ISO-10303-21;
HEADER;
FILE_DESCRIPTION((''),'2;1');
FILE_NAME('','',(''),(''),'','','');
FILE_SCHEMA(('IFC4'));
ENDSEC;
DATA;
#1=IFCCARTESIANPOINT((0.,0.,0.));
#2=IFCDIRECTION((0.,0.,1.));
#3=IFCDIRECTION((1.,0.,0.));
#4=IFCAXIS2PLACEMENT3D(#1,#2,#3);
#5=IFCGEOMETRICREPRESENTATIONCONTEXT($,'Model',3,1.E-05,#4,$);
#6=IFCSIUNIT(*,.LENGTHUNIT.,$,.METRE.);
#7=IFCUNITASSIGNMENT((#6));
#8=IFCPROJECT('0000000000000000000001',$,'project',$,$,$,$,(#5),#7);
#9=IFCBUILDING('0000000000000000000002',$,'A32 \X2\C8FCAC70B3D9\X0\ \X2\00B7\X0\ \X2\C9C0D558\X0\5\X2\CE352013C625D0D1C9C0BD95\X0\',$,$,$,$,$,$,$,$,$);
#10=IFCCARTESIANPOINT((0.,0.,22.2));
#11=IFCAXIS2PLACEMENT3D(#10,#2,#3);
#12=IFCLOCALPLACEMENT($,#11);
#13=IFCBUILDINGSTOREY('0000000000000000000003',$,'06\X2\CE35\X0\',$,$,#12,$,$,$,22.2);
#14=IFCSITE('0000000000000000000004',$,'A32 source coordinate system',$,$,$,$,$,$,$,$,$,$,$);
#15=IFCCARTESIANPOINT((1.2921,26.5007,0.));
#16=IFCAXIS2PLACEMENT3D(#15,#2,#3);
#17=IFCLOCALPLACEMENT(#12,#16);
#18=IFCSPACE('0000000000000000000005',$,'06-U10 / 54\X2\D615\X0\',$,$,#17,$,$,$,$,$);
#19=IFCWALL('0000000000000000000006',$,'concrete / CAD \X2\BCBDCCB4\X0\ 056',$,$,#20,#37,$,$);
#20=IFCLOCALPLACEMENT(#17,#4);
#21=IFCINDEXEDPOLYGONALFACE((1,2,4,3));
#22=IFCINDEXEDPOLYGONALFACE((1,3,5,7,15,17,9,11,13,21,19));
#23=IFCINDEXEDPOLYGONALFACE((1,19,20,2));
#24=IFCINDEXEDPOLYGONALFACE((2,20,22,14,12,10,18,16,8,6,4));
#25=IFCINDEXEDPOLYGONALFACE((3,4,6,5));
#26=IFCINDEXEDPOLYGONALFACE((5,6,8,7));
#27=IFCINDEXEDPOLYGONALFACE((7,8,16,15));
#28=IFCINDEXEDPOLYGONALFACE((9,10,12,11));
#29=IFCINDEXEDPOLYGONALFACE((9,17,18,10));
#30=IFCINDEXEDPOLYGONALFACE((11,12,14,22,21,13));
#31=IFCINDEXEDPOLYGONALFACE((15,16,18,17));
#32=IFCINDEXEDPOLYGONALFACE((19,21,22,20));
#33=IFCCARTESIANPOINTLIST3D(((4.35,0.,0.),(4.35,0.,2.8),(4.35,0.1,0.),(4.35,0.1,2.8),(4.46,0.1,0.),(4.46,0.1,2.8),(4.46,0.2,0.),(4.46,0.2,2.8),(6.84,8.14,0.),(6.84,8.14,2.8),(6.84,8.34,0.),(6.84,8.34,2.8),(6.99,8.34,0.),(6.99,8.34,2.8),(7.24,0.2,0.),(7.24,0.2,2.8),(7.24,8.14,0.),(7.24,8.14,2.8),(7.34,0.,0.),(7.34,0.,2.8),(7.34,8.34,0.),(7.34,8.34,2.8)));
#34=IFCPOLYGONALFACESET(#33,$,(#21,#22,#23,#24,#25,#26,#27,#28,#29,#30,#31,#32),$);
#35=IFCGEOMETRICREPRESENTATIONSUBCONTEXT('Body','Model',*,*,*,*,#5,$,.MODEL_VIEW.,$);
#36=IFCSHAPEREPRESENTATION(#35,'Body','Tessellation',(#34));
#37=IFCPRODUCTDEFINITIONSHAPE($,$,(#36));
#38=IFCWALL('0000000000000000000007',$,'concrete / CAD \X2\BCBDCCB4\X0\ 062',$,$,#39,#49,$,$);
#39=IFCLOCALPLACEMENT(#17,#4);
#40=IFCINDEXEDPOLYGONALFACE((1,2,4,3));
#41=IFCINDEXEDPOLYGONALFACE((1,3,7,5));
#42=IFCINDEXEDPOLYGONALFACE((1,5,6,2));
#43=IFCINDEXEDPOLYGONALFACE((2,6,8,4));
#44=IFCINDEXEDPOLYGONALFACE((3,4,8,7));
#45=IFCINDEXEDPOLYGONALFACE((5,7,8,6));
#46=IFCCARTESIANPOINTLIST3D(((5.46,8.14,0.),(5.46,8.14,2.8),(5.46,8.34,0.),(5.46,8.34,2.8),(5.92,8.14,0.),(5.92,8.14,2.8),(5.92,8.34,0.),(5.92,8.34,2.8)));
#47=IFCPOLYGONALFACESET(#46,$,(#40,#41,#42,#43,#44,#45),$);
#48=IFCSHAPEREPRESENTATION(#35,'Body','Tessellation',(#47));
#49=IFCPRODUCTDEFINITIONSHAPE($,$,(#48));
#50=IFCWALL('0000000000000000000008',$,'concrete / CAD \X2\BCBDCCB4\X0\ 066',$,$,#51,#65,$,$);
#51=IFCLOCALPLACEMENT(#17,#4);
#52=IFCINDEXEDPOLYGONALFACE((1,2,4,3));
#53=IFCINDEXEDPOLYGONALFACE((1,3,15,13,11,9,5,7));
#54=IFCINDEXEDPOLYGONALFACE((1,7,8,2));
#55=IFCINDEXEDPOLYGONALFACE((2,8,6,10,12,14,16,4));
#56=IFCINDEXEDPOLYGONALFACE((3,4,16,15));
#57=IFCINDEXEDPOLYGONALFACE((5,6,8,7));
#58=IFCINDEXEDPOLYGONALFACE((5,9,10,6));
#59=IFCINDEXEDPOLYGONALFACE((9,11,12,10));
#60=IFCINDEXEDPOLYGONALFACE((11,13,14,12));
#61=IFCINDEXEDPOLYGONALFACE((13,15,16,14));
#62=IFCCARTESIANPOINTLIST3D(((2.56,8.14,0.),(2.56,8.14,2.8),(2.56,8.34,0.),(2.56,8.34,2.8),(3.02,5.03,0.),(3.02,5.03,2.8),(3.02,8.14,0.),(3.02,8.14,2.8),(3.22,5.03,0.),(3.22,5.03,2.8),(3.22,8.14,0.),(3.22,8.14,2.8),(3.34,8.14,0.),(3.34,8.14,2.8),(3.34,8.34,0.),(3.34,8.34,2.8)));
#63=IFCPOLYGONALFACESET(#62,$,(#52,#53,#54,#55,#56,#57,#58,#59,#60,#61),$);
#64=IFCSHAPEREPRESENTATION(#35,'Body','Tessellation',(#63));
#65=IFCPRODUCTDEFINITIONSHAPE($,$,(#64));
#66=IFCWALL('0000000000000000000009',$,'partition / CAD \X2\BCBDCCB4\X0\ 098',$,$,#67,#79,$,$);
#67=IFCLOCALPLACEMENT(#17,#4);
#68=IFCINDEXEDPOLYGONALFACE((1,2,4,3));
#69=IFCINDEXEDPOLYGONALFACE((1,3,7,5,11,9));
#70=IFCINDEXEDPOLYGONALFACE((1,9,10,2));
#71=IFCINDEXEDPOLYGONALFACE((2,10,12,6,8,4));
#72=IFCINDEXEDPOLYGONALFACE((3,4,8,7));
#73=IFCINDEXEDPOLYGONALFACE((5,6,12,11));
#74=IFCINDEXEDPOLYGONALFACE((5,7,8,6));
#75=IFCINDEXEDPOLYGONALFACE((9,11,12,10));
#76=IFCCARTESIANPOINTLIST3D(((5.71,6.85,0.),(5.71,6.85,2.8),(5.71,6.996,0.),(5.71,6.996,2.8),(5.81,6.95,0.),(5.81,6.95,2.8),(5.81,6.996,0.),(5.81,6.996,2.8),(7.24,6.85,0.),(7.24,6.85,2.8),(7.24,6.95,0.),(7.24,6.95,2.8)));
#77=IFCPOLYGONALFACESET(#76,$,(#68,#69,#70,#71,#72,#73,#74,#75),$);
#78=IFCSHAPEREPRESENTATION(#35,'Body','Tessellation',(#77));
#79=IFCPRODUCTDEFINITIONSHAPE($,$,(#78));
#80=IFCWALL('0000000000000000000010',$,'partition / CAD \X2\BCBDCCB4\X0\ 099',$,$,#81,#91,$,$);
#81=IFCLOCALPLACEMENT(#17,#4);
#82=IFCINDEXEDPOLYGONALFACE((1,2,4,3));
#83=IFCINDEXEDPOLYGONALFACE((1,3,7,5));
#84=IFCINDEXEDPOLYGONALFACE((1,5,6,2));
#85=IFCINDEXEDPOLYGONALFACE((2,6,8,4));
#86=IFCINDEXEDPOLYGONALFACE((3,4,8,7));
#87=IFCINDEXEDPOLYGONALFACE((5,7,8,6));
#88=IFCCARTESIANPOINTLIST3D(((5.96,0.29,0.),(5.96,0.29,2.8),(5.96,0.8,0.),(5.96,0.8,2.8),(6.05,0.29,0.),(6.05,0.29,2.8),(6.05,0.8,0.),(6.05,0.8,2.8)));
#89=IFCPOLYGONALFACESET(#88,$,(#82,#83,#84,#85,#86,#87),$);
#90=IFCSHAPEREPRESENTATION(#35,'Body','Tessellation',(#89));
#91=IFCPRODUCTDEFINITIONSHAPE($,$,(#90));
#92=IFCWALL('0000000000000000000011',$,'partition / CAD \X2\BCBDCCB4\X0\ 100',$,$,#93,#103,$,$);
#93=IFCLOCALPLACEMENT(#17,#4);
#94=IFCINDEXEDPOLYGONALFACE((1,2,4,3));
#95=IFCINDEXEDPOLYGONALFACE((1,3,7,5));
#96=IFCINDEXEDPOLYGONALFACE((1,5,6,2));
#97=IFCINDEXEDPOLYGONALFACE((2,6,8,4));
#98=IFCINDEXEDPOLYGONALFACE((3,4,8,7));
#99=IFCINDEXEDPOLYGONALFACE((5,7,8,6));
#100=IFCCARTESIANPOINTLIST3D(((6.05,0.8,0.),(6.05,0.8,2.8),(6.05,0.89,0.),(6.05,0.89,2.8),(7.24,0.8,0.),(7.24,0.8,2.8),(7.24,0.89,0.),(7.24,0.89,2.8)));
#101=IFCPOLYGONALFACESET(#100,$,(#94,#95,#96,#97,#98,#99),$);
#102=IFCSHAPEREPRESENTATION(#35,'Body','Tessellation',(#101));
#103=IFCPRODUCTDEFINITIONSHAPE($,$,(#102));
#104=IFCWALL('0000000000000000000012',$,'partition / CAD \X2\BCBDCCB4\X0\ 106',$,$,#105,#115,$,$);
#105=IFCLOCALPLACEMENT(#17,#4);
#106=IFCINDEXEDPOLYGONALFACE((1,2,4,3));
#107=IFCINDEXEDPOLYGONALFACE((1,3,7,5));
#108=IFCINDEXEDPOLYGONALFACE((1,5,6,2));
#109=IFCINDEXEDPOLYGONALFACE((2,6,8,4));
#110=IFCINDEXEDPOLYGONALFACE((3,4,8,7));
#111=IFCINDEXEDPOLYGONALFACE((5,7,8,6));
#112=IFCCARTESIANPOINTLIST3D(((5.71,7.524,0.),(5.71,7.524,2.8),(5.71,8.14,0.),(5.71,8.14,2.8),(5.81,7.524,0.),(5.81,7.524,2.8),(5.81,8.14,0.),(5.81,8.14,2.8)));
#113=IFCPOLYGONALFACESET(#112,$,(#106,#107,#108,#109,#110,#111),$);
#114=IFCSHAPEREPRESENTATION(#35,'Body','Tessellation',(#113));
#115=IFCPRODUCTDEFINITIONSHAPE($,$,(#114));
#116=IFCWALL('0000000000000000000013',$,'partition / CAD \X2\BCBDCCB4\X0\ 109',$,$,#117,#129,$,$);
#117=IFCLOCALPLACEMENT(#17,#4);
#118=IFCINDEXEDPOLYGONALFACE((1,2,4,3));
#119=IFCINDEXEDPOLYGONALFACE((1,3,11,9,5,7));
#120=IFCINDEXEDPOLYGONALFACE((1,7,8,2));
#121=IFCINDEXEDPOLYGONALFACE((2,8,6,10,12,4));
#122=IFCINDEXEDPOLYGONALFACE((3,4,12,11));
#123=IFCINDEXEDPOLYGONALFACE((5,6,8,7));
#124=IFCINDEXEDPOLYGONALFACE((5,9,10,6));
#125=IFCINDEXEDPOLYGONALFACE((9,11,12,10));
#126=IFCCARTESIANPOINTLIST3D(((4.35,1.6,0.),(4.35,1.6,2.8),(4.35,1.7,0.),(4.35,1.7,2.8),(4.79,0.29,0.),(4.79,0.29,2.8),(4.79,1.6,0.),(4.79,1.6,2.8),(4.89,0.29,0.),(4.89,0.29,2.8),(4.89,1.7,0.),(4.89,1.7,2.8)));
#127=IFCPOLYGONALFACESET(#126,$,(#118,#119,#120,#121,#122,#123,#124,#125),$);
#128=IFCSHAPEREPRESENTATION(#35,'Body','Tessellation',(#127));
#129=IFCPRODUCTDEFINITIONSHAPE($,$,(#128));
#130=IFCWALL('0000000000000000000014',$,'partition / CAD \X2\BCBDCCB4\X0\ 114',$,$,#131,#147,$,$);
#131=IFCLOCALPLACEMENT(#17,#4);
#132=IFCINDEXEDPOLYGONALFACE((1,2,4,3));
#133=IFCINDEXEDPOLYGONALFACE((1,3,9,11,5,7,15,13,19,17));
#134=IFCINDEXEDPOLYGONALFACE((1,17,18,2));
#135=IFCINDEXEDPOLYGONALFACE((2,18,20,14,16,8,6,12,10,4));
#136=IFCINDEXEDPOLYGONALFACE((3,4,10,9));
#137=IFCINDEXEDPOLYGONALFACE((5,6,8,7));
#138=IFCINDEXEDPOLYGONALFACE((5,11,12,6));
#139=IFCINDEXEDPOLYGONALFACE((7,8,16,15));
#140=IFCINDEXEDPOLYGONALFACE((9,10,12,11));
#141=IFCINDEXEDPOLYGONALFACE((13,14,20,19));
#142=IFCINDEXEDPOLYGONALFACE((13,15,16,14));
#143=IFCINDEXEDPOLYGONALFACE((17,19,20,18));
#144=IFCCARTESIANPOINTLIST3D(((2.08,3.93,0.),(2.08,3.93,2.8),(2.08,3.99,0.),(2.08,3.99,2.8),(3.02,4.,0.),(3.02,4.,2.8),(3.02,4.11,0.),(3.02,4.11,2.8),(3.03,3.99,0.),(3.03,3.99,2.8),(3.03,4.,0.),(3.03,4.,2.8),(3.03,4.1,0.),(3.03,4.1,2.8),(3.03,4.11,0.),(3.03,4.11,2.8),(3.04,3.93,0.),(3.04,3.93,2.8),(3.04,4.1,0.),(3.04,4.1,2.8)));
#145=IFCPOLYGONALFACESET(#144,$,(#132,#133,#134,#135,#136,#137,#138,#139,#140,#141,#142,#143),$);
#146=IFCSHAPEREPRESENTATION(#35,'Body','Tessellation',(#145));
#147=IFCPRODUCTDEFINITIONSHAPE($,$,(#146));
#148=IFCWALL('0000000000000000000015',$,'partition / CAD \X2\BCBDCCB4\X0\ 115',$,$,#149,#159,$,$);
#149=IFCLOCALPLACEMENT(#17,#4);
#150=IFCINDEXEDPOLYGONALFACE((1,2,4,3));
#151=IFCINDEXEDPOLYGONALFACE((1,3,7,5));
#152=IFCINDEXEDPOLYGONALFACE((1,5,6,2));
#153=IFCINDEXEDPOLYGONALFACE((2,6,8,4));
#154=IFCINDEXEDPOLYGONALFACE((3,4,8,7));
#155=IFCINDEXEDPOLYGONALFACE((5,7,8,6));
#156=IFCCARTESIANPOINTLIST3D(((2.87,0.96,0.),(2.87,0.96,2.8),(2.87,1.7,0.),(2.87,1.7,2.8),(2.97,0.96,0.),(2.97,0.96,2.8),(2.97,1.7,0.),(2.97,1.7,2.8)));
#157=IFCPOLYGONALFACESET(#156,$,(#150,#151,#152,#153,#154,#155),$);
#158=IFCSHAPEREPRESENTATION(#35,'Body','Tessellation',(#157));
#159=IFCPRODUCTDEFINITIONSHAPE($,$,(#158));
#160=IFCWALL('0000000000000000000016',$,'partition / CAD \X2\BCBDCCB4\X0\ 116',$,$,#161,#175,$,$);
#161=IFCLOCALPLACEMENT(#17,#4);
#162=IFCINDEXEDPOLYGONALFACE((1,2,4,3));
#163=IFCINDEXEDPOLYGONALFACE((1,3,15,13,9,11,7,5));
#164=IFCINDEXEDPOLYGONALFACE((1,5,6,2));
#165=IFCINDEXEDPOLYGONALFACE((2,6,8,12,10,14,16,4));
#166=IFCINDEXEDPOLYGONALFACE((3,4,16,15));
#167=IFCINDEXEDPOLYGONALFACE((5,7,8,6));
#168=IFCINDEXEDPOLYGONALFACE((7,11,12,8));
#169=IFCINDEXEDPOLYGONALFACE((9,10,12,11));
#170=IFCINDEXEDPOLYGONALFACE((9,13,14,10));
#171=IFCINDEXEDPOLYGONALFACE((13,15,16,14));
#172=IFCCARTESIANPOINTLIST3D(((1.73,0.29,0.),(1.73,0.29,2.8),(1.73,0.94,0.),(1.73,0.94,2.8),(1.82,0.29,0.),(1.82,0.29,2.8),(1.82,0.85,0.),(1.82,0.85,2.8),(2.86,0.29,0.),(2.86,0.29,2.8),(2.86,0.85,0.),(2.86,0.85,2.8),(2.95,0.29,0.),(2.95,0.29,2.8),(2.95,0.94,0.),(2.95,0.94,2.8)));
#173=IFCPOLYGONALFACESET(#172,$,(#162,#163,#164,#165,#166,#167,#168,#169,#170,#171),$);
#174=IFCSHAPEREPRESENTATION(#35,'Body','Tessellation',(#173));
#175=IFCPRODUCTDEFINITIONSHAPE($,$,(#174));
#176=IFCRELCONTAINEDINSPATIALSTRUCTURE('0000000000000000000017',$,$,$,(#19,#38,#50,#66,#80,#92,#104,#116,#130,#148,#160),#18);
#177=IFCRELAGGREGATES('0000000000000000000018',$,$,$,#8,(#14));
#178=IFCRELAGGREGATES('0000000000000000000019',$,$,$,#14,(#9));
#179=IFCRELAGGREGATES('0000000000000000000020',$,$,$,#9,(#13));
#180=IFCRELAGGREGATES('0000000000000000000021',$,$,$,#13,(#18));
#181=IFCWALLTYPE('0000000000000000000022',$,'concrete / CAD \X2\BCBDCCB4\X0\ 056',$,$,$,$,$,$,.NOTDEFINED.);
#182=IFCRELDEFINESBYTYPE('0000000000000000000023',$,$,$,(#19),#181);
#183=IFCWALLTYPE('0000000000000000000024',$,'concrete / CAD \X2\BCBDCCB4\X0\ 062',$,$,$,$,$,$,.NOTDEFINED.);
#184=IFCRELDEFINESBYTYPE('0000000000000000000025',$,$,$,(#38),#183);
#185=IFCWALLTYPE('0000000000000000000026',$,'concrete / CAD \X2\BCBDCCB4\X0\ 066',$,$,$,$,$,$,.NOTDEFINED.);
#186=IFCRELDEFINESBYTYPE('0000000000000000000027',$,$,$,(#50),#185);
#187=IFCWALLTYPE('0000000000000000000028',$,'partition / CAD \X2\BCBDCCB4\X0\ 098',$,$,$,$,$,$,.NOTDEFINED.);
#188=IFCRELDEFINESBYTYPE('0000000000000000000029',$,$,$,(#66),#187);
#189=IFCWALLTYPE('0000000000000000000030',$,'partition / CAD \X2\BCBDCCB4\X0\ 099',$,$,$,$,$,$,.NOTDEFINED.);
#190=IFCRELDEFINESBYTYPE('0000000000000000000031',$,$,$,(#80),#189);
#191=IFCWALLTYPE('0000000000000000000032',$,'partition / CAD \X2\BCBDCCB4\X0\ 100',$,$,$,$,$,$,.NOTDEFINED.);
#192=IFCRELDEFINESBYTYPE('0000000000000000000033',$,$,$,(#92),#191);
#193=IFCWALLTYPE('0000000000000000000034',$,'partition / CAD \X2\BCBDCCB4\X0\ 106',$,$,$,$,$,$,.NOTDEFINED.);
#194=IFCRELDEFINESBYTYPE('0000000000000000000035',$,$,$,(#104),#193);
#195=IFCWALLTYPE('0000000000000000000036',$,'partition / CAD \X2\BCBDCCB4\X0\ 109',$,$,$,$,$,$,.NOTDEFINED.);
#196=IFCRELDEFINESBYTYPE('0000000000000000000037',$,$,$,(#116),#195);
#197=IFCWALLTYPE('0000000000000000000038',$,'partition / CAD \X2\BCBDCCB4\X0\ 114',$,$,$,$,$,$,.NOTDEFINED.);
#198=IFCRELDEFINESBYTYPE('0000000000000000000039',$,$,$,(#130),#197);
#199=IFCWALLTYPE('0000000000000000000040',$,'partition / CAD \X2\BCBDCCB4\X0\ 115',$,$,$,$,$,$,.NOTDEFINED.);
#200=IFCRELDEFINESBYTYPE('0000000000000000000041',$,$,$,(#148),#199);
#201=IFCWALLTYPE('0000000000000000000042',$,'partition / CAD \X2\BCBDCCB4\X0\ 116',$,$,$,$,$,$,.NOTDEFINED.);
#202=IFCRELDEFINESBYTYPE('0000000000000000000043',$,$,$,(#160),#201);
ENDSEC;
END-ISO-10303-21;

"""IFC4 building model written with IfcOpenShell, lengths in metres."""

from ifc_helpers import new_model, si_unit, frame, origin, origin_with_axes, place, context, subcontext, project, spatial, polyline, outline, extrude, source, transform, mapped, type_object, type_shapes, element, save


model = new_model("IFC4")

# Units and contexts
model_context = context("Model", 3, precision=1e-05, world=origin_with_axes())
body_context = subcontext(model_context, "Body", "Model", "MODEL_VIEW")
ifc_project = project(units=[si_unit("LENGTHUNIT", "METRE")], contexts=[model_context])

# Site, building, storey, space
site = spatial("IfcSite", under=ifc_project, Name="A32 source coordinate system")
building = spatial("IfcBuilding", under=site, Name="A32 주거동 · 지하5층–옥탑지붕")
storey_placement = place(None, frame((0.0, 0.0, 22.2), z_axis=(0.0, 0.0, 1.0), x_axis=(1.0, 0.0, 0.0)))
storey = spatial("IfcBuildingStorey", under=building, at=storey_placement, Name="06층", Elevation=22.2)
space_placement = place(storey_placement, frame((1.2921, 26.5007, 0.0), z_axis=(0.0, 0.0, 1.0), x_axis=(1.0, 0.0, 0.0)))
space = spatial("IfcSpace", under=storey, at=space_placement, Name="06-U10 / 54형")

# Walls
wall_type_1 = type_object("IfcWallType", Name="concrete / CAD 벽체 056", PredefinedType="NOTDEFINED")
shared_shape_1 = source(origin(), body_context, "Body", "SweptSolid", [
    extrude(outline(polyline([(7.24, 0.2), (7.24, 8.14), (6.84, 8.14), (6.84, 8.34), (6.99, 8.34), (6.99, 8.34), (7.34, 8.34), (7.34, 0.0), (4.35, 0.0), (4.35, 0.1), (4.46, 0.1), (4.46, 0.2), (7.24, 0.2)])), origin(), (0.0, 0.0, 1.0), 2.8),
])
type_shapes(wall_type_1, [shared_shape_1])
wall_1_placement = place(space_placement, origin_with_axes())
element("IfcWall", 1, at=wall_1_placement, inside=space, type_object=wall_type_1, Name="concrete / CAD 벽체 056", context=body_context, shape_type="MappedRepresentation", body=[
    mapped(shared_shape_1, transform((0.0, 0.0, 0.0), scale=1.0)),
])
wall_type_2 = type_object("IfcWallType", Name="concrete / CAD 벽체 062", PredefinedType="NOTDEFINED")
shared_shape_2 = source(origin(), body_context, "Body", "SweptSolid", [
    extrude(outline(polyline([(5.46, 8.14), (5.46, 8.34), (5.92, 8.34), (5.92, 8.14), (5.46, 8.14)])), origin(), (0.0, 0.0, 1.0), 2.8),
])
type_shapes(wall_type_2, [shared_shape_2])
wall_2_placement = place(space_placement, origin_with_axes())
element("IfcWall", 2, at=wall_2_placement, inside=space, type_object=wall_type_2, Name="concrete / CAD 벽체 062", context=body_context, shape_type="MappedRepresentation", body=[
    mapped(shared_shape_2, transform((0.0, 0.0, 0.0), scale=1.0)),
])
wall_type_3 = type_object("IfcWallType", Name="concrete / CAD 벽체 066", PredefinedType="NOTDEFINED")
shared_shape_3 = source(origin(), body_context, "Body", "SweptSolid", [
    extrude(outline(polyline([(3.22, 8.14), (3.22, 5.03), (3.02, 5.03), (3.02, 8.14), (2.56, 8.14), (2.56, 8.34), (3.34, 8.34), (3.34, 8.14), (3.22, 8.14)])), origin(), (0.0, 0.0, 1.0), 2.8),
])
type_shapes(wall_type_3, [shared_shape_3])
wall_3_placement = place(space_placement, origin_with_axes())
element("IfcWall", 3, at=wall_3_placement, inside=space, type_object=wall_type_3, Name="concrete / CAD 벽체 066", context=body_context, shape_type="MappedRepresentation", body=[
    mapped(shared_shape_3, transform((0.0, 0.0, 0.0), scale=1.0)),
])
wall_type_4 = type_object("IfcWallType", Name="partition / CAD 벽체 098", PredefinedType="NOTDEFINED")
shared_shape_4 = source(origin(), body_context, "Body", "SweptSolid", [
    extrude(outline(polyline([(5.71, 6.996), (5.81, 6.996), (5.81, 6.95), (7.24, 6.95), (7.24, 6.85), (5.71, 6.85), (5.71, 6.996)])), origin(), (0.0, 0.0, 1.0), 2.8),
])
type_shapes(wall_type_4, [shared_shape_4])
wall_4_placement = place(space_placement, origin_with_axes())
element("IfcWall", 4, at=wall_4_placement, inside=space, type_object=wall_type_4, Name="partition / CAD 벽체 098", context=body_context, shape_type="MappedRepresentation", body=[
    mapped(shared_shape_4, transform((0.0, 0.0, 0.0), scale=1.0)),
])
wall_type_5 = type_object("IfcWallType", Name="partition / CAD 벽체 099", PredefinedType="NOTDEFINED")
shared_shape_5 = source(origin(), body_context, "Body", "SweptSolid", [
    extrude(outline(polyline([(6.05, 0.8), (6.05, 0.29), (5.96, 0.29), (5.96, 0.8), (6.05, 0.8)])), origin(), (0.0, 0.0, 1.0), 2.8),
])
type_shapes(wall_type_5, [shared_shape_5])
wall_5_placement = place(space_placement, origin_with_axes())
element("IfcWall", 5, at=wall_5_placement, inside=space, type_object=wall_type_5, Name="partition / CAD 벽체 099", context=body_context, shape_type="MappedRepresentation", body=[
    mapped(shared_shape_5, transform((0.0, 0.0, 0.0), scale=1.0)),
])
wall_type_6 = type_object("IfcWallType", Name="partition / CAD 벽체 100", PredefinedType="NOTDEFINED")
shared_shape_6 = source(origin(), body_context, "Body", "SweptSolid", [
    extrude(outline(polyline([(7.24, 0.8), (6.05, 0.8), (6.05, 0.89), (7.24, 0.89), (7.24, 0.8)])), origin(), (0.0, 0.0, 1.0), 2.8),
])
type_shapes(wall_type_6, [shared_shape_6])
wall_6_placement = place(space_placement, origin_with_axes())
element("IfcWall", 6, at=wall_6_placement, inside=space, type_object=wall_type_6, Name="partition / CAD 벽체 100", context=body_context, shape_type="MappedRepresentation", body=[
    mapped(shared_shape_6, transform((0.0, 0.0, 0.0), scale=1.0)),
])
wall_type_7 = type_object("IfcWallType", Name="partition / CAD 벽체 106", PredefinedType="NOTDEFINED")
shared_shape_7 = source(origin(), body_context, "Body", "SweptSolid", [
    extrude(outline(polyline([(5.71, 8.14), (5.81, 8.14), (5.81, 7.524), (5.71, 7.524), (5.71, 8.14)])), origin(), (0.0, 0.0, 1.0), 2.8),
])
type_shapes(wall_type_7, [shared_shape_7])
wall_7_placement = place(space_placement, origin_with_axes())
element("IfcWall", 7, at=wall_7_placement, inside=space, type_object=wall_type_7, Name="partition / CAD 벽체 106", context=body_context, shape_type="MappedRepresentation", body=[
    mapped(shared_shape_7, transform((0.0, 0.0, 0.0), scale=1.0)),
])
wall_type_8 = type_object("IfcWallType", Name="partition / CAD 벽체 109", PredefinedType="NOTDEFINED")
shared_shape_8 = source(origin(), body_context, "Body", "SweptSolid", [
    extrude(outline(polyline([(4.79, 1.6), (4.35, 1.6), (4.35, 1.7), (4.89, 1.7), (4.89, 0.29), (4.79, 0.29), (4.79, 1.6)])), origin(), (0.0, 0.0, 1.0), 2.8),
])
type_shapes(wall_type_8, [shared_shape_8])
wall_8_placement = place(space_placement, origin_with_axes())
element("IfcWall", 8, at=wall_8_placement, inside=space, type_object=wall_type_8, Name="partition / CAD 벽체 109", context=body_context, shape_type="MappedRepresentation", body=[
    mapped(shared_shape_8, transform((0.0, 0.0, 0.0), scale=1.0)),
])
wall_type_9 = type_object("IfcWallType", Name="partition / CAD 벽체 114", PredefinedType="NOTDEFINED")
shared_shape_9 = source(origin(), body_context, "Body", "SweptSolid", [
    extrude(outline(polyline([(2.08, 3.99), (3.03, 3.99), (3.03, 4.0), (3.02, 4.0), (3.02, 4.11), (3.03, 4.11), (3.03, 4.1), (3.04, 4.1), (3.04, 3.93), (2.08, 3.93), (2.08, 3.99)])), origin(), (0.0, 0.0, 1.0), 2.8),
])
type_shapes(wall_type_9, [shared_shape_9])
wall_9_placement = place(space_placement, origin_with_axes())
element("IfcWall", 9, at=wall_9_placement, inside=space, type_object=wall_type_9, Name="partition / CAD 벽체 114", context=body_context, shape_type="MappedRepresentation", body=[
    mapped(shared_shape_9, transform((0.0, 0.0, 0.0), scale=1.0)),
])
wall_type_10 = type_object("IfcWallType", Name="partition / CAD 벽체 115", PredefinedType="NOTDEFINED")
shared_shape_10 = source(origin(), body_context, "Body", "SweptSolid", [
    extrude(outline(polyline([(2.87, 1.7), (2.97, 1.7), (2.97, 0.96), (2.87, 0.96), (2.87, 1.7)])), origin(), (0.0, 0.0, 1.0), 2.8),
])
type_shapes(wall_type_10, [shared_shape_10])
wall_10_placement = place(space_placement, origin_with_axes())
element("IfcWall", 10, at=wall_10_placement, inside=space, type_object=wall_type_10, Name="partition / CAD 벽체 115", context=body_context, shape_type="MappedRepresentation", body=[
    mapped(shared_shape_10, transform((0.0, 0.0, 0.0), scale=1.0)),
])
wall_type_11 = type_object("IfcWallType", Name="partition / CAD 벽체 116", PredefinedType="NOTDEFINED")
shared_shape_11 = source(origin(), body_context, "Body", "SweptSolid", [
    extrude(outline(polyline([(2.95, 0.29), (2.86, 0.29), (2.86, 0.85), (1.82, 0.85), (1.82, 0.29), (1.73, 0.29), (1.73, 0.94), (2.95, 0.94), (2.95, 0.29)])), origin(), (0.0, 0.0, 1.0), 2.8),
])
type_shapes(wall_type_11, [shared_shape_11])
wall_11_placement = place(space_placement, origin_with_axes())
element("IfcWall", 11, at=wall_11_placement, inside=space, type_object=wall_type_11, Name="partition / CAD 벽체 116", context=body_context, shape_type="MappedRepresentation", body=[
    mapped(shared_shape_11, transform((0.0, 0.0, 0.0), scale=1.0)),
])

save(model, "model.ifc")
